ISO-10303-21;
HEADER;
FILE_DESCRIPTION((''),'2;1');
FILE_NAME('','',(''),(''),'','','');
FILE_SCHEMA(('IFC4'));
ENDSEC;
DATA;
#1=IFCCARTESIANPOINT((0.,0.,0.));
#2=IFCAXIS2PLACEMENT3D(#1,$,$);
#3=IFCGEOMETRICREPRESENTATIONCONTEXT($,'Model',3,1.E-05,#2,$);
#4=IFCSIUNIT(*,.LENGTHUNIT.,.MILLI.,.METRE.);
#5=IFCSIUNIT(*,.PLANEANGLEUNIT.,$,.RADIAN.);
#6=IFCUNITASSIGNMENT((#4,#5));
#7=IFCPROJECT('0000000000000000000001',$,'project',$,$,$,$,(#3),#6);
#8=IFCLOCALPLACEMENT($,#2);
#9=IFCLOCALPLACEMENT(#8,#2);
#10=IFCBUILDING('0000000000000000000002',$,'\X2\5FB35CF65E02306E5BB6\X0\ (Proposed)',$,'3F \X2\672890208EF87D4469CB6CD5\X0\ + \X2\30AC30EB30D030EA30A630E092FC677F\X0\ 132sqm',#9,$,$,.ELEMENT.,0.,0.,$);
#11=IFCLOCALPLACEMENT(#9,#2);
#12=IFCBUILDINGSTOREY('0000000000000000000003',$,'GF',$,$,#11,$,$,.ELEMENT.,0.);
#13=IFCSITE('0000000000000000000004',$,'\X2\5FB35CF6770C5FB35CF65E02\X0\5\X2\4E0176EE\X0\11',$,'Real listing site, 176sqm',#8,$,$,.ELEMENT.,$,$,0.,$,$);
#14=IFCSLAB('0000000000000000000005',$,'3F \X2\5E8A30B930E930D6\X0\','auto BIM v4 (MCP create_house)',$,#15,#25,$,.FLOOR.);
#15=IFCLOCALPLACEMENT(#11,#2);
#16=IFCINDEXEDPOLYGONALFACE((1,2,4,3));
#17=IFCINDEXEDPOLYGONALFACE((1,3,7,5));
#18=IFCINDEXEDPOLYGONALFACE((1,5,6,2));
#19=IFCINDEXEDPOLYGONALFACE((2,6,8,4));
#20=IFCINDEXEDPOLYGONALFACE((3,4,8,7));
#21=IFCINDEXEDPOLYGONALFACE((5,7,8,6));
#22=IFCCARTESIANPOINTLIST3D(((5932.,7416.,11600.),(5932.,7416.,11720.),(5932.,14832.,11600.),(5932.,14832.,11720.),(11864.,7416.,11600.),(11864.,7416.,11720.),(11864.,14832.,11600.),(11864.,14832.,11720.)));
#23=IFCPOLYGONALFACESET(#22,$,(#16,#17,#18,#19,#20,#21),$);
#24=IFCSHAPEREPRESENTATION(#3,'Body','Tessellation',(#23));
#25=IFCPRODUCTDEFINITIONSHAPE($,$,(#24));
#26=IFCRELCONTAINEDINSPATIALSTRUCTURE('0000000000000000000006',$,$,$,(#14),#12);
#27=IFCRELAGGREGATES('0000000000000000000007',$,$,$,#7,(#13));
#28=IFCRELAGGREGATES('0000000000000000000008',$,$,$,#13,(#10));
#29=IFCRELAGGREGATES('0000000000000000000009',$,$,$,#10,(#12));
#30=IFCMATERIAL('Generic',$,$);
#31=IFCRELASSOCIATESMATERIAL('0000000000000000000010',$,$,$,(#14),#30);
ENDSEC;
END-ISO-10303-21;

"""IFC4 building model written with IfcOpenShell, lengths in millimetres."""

from ifc_helpers import new_model, si_unit, frame, frame_2d, origin, place, context, project, spatial, rectangle, extrude, material, element, save


model = new_model("IFC4")

# Units and contexts
model_context = context("Model", 3, precision=1e-05, world=origin())
ifc_project = project(units=[si_unit("LENGTHUNIT", "METRE", prefix="MILLI"), si_unit("PLANEANGLEUNIT", "RADIAN")], contexts=[model_context])

# Site, building, storey
site_placement = place(None, origin())
site = spatial("IfcSite", under=ifc_project, at=site_placement, Name="徳島県徳島市5丁目11", ObjectType="Real listing site, 176sqm", CompositionType="ELEMENT", RefElevation=0.0)
building_placement = place(site_placement, origin())
building = spatial("IfcBuilding", under=site, at=building_placement, Name="徳島市の家 (Proposed)", ObjectType="3F 木造軸組構法 + ガルバリウム鋼板 132sqm", CompositionType="ELEMENT", ElevationOfRefHeight=0.0, ElevationOfTerrain=0.0)
storey_placement = place(building_placement, origin())
storey = spatial("IfcBuildingStorey", under=building, at=storey_placement, Name="GF", CompositionType="ELEMENT", Elevation=0.0)

# Slab
ifc_material = material(Name="Generic")
slab_placement = place(storey_placement, frame((2966.0, 3708.0, 5800.0)))
element("IfcSlab", 1, at=slab_placement, inside=storey, material=ifc_material, Name="3F 床スラブ", Description="auto BIM v4 (MCP create_house)", PredefinedType="FLOOR", context=model_context, shape_type="SweptSolid", body=[
    extrude(rectangle(XDim=5932.0, YDim=7416.0, at=frame_2d((2966.0, 3708.0))), frame((2966.0, 3708.0, 5800.0)), (0.0, 0.0, 1.0), 120.0),
])

save(model, "model.ifc")
